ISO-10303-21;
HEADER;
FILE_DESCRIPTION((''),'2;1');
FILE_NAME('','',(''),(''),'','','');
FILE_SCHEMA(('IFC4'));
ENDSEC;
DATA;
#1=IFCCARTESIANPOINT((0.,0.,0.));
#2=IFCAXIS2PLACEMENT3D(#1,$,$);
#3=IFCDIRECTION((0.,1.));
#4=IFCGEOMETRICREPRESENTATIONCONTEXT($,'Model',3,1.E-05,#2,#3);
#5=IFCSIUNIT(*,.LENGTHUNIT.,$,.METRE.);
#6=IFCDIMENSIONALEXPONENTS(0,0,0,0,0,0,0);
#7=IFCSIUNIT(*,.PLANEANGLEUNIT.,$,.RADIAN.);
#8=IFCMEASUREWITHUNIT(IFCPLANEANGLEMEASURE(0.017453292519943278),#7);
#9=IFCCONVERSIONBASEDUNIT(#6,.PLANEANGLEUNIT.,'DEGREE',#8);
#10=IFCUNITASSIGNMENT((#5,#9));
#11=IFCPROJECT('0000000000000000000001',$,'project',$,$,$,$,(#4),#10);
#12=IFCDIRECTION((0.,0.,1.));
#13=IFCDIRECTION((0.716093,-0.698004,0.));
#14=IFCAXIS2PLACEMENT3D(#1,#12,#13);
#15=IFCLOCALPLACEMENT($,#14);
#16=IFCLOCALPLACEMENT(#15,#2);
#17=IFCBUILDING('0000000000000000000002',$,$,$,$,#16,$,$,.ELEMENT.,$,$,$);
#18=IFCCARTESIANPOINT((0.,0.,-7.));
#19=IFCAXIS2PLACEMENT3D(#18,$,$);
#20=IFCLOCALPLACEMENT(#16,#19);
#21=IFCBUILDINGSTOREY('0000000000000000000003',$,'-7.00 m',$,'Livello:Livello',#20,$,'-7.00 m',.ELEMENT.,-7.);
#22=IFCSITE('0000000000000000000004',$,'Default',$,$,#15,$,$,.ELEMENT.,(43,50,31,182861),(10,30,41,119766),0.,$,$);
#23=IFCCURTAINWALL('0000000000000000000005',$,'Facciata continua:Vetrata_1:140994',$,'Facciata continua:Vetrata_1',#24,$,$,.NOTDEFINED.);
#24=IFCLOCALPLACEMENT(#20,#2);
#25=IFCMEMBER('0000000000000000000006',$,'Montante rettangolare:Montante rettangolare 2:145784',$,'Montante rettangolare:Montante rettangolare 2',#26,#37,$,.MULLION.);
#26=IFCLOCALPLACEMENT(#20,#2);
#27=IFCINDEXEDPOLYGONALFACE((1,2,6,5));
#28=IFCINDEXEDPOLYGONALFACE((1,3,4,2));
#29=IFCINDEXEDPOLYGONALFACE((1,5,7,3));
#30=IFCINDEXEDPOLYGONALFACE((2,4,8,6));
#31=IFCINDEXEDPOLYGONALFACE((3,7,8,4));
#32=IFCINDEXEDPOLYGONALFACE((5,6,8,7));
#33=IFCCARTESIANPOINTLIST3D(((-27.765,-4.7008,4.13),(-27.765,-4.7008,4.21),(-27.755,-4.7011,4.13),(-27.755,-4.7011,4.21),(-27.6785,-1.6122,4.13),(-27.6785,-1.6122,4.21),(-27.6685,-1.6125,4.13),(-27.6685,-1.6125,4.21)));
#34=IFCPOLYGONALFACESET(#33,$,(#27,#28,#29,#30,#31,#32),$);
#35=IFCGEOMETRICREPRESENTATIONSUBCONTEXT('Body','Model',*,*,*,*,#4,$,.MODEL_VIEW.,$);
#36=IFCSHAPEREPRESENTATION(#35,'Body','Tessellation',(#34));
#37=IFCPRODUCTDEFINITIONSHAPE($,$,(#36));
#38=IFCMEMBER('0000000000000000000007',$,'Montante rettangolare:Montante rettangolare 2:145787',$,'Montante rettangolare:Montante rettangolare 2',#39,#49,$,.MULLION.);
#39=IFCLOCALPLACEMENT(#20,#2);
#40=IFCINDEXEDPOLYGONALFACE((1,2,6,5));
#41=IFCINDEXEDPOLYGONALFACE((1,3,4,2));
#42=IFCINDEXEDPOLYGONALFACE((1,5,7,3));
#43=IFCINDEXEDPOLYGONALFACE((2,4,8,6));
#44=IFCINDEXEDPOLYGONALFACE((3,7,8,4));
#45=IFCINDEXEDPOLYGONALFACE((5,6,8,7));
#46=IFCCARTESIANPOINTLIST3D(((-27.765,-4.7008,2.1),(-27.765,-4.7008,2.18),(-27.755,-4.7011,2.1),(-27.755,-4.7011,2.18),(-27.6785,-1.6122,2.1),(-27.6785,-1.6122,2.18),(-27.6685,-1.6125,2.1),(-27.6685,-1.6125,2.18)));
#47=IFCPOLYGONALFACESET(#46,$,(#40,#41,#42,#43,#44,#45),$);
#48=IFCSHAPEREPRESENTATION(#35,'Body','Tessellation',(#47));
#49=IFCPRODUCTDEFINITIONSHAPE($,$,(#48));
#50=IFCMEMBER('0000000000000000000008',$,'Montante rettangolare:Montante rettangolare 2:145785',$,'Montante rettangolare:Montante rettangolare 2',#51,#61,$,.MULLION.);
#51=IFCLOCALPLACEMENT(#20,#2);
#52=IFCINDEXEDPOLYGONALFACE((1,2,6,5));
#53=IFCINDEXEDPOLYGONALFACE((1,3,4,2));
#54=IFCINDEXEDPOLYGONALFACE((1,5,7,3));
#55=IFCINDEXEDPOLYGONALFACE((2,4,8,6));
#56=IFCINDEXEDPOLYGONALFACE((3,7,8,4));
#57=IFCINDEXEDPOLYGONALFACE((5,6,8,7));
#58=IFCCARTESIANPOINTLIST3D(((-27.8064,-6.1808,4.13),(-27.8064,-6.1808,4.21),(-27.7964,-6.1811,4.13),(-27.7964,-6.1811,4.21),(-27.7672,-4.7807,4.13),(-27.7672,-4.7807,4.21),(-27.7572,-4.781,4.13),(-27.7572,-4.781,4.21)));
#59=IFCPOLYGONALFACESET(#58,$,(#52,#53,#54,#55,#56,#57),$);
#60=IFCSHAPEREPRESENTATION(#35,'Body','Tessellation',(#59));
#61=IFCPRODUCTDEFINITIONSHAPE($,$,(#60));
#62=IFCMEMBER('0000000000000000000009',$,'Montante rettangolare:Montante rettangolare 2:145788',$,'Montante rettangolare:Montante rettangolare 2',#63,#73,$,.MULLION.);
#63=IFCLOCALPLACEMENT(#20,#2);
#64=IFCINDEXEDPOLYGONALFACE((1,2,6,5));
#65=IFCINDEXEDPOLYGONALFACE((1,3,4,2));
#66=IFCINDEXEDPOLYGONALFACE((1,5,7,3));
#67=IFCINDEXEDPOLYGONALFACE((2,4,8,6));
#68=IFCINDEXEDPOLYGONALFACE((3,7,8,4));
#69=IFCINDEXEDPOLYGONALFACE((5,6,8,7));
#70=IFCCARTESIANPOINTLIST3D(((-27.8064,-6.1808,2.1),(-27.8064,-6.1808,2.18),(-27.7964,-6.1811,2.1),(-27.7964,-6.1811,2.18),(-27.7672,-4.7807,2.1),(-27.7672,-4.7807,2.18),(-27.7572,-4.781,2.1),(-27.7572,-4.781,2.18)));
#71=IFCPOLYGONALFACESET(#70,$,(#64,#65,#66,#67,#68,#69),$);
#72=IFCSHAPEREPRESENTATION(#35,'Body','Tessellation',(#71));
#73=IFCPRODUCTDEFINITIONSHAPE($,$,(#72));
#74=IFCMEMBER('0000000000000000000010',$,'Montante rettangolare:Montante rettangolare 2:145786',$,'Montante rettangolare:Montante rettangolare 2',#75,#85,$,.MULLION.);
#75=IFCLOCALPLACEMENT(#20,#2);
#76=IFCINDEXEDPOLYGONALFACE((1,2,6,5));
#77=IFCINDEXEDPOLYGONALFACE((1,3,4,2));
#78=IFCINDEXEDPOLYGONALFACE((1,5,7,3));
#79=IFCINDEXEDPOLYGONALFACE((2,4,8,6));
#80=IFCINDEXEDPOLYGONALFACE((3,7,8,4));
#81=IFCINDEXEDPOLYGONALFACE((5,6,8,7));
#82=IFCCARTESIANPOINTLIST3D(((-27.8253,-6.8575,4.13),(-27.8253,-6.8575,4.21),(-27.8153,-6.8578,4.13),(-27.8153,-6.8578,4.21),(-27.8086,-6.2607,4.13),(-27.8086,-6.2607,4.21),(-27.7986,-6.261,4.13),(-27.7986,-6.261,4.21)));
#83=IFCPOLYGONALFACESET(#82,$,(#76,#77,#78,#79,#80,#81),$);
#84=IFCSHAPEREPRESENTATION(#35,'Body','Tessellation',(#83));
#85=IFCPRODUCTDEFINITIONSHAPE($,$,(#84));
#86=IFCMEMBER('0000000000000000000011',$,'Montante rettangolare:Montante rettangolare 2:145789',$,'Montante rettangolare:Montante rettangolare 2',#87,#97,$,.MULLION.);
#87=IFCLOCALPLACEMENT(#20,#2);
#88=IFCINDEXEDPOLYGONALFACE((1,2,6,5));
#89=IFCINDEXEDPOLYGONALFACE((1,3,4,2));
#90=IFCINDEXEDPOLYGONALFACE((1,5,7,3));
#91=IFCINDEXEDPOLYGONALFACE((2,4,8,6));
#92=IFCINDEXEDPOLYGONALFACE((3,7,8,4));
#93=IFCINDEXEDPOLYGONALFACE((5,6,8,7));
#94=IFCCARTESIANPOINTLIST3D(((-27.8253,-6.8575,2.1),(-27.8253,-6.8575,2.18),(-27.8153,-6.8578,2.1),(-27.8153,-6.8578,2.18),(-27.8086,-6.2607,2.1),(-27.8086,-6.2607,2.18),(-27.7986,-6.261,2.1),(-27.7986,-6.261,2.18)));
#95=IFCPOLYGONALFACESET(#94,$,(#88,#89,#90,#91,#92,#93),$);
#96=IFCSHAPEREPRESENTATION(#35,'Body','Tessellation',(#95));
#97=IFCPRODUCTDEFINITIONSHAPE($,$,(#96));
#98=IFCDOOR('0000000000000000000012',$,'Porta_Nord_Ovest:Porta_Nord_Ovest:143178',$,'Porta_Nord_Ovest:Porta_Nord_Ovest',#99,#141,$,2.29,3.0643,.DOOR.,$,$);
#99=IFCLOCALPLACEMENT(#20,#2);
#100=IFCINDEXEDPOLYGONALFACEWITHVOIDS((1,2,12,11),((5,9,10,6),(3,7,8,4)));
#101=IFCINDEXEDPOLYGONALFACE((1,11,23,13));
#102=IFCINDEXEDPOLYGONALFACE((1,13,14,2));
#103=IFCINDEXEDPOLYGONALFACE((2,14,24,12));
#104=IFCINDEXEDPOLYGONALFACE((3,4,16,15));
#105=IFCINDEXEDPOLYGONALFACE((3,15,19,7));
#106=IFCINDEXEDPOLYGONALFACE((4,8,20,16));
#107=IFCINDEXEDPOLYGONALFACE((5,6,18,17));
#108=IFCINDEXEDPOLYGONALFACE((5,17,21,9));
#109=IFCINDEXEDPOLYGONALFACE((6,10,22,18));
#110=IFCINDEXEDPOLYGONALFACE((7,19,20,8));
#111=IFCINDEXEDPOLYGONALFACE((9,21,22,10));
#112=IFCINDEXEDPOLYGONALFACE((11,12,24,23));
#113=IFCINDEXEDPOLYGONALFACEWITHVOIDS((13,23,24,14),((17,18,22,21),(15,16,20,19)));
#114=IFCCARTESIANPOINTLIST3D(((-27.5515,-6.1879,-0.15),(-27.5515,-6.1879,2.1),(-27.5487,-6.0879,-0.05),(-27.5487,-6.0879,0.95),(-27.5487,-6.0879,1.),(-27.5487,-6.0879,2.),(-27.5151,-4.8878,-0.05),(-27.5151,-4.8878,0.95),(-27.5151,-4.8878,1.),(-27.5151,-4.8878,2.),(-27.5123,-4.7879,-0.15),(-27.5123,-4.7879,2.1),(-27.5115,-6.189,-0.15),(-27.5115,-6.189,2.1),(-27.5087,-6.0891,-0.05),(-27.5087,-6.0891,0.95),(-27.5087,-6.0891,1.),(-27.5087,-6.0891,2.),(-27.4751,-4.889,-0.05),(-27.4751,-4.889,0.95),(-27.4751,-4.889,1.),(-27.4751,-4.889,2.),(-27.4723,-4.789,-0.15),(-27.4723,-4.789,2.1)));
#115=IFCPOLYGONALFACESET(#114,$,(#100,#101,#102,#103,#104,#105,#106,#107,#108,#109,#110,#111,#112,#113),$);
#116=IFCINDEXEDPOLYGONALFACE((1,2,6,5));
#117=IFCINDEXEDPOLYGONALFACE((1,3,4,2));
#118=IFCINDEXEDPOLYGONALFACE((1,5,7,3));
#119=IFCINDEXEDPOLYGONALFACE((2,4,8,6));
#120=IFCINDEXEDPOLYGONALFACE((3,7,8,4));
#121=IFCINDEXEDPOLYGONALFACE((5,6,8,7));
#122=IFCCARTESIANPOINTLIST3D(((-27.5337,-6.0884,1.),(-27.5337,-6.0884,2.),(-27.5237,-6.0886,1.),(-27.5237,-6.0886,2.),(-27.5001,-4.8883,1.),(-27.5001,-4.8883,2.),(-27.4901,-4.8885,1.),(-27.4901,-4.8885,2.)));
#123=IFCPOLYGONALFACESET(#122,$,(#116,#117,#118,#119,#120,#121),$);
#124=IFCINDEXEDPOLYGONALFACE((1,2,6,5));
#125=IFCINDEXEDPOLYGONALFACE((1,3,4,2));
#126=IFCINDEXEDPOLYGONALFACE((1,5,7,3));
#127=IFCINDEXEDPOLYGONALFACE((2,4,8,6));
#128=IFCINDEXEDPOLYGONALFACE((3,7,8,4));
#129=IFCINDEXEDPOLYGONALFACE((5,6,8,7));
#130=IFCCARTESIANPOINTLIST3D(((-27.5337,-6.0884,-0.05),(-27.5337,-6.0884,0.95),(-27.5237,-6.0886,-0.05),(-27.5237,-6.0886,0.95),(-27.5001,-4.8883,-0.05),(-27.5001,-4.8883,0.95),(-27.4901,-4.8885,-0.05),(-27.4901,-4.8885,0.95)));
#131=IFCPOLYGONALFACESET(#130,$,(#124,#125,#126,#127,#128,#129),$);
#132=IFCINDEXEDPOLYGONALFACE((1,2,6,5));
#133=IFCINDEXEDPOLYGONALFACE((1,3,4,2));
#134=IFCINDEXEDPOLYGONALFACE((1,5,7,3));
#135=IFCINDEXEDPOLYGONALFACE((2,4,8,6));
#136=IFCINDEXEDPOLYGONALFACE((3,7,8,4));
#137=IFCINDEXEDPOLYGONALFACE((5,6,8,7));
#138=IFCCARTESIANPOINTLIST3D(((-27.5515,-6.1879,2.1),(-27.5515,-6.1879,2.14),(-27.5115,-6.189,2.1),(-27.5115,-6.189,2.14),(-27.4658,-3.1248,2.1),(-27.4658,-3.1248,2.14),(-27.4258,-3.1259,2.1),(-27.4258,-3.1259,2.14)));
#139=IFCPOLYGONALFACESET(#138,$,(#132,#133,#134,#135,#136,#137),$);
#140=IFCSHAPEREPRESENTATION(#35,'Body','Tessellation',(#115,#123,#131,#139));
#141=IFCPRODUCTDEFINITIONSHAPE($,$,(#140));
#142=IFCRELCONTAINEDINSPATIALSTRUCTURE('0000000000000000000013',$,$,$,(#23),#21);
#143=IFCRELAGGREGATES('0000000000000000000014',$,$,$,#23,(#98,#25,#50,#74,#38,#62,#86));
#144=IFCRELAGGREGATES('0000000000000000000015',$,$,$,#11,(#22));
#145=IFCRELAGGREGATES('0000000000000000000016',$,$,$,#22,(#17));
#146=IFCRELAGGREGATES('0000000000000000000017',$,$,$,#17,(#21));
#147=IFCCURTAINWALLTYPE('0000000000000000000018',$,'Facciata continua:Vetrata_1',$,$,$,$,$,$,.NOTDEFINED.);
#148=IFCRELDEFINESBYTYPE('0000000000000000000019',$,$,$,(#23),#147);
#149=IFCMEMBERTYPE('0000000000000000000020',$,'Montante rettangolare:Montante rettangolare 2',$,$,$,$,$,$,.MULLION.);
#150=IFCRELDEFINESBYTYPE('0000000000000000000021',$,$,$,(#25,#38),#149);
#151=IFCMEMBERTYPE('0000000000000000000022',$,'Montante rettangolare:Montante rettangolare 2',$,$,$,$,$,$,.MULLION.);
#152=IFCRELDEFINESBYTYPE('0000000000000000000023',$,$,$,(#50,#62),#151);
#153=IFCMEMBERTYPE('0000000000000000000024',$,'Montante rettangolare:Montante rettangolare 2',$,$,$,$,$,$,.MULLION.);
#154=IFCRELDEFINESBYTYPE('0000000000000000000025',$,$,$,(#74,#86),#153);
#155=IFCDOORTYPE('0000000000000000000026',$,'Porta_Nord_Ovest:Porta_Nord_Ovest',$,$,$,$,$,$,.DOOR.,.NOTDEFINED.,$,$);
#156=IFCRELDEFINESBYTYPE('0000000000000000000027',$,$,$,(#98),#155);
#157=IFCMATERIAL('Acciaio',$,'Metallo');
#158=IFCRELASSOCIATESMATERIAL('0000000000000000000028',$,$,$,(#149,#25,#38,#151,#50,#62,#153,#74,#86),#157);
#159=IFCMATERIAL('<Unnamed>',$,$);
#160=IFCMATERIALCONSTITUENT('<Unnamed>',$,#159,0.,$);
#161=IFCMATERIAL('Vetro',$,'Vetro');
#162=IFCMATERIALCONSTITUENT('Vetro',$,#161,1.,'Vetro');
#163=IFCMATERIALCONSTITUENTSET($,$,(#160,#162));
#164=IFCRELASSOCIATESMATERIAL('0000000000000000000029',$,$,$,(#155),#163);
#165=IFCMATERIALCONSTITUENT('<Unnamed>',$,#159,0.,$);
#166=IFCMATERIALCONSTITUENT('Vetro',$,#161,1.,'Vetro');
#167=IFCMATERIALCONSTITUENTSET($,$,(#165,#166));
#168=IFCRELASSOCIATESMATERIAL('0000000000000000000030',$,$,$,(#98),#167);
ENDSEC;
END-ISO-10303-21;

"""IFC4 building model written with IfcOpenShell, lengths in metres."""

from ifc_helpers import new_model, entity, si_unit, converted_unit, direction, frame, origin, place, context, subcontext, project, spatial, indexed_curve, outline, extrude, source, transform, mapped, material, constituent, constituent_set, type_object, type_shapes, element, aggregate, save


model = new_model("IFC4")

# Units and contexts
model_context = context("Model", 3, precision=1e-05, world=origin(), true_north=direction((0.0, 1.0)))
body_context = subcontext(model_context, "Body", "Model", "MODEL_VIEW")
ifc_project = project(units=[si_unit("LENGTHUNIT", "METRE"), converted_unit("PLANEANGLEUNIT", "DEGREE", entity("IfcPlaneAngleMeasure", 0.017453292519943278), si_unit("PLANEANGLEUNIT", "RADIAN"), dimensions=[0, 0, 0, 0, 0, 0, 0])], contexts=[model_context])

# Site, building, storey
site_placement = place(None, frame((0.0, 0.0, 0.0), z_axis=(0.0, 0.0, 1.0), x_axis=(0.716093, -0.698004, 0.0)))
site = spatial("IfcSite", under=ifc_project, at=site_placement, Name="Default", CompositionType="ELEMENT", RefLatitude=(43, 50, 31, 182861), RefLongitude=(10, 30, 41, 119766), RefElevation=0.0)
building_placement = place(site_placement, origin())
building = spatial("IfcBuilding", under=site, at=building_placement, CompositionType="ELEMENT")
storey_placement = place(building_placement, frame((0.0, 0.0, -7.0)))
storey = spatial("IfcBuildingStorey", under=building, at=storey_placement, Name="-7.00 m", ObjectType="Livello:Livello", LongName="-7.00 m", CompositionType="ELEMENT", Elevation=-7.0)

# Curtain wall
ifc_material_1 = material(Name="Acciaio", Category="Metallo")
curtain_wall_type_1 = type_object("IfcCurtainWallType", Name="Facciata continua:Vetrata_1", PredefinedType="NOTDEFINED")
curtain_wall_1_placement = place(storey_placement, frame((0.0, 0.0, 7.0)))
curtain_wall_1 = element("IfcCurtainWall", 1, at=curtain_wall_1_placement, inside=storey, type_object=curtain_wall_type_1, Name="Facciata continua:Vetrata_1:140994", ObjectType="Facciata continua:Vetrata_1", PredefinedType="NOTDEFINED")

# Members
member_type_1 = type_object("IfcMemberType", Name="Montante rettangolare:Montante rettangolare 2", PredefinedType="MULLION", material=ifc_material_1)
shared_shape_1 = source(origin(), body_context, "Body", "SweptSolid", [
    extrude(outline(indexed_curve([(-0.04, -0.005), (0.04, -0.005), (0.04, 0.005), (-0.04, 0.005), (-0.04, -0.005)], self_intersect=False)), frame((0.0, 0.01, -3.0898), z_axis=(0.0, 0.0, 1.0), x_axis=(-1.0, 0.0, 0.0)), (0.0, 0.0, 1.0), 3.0898),
])
type_shapes(member_type_1, [shared_shape_1])
member_1_placement = place(curtain_wall_1_placement, frame((-27.75, -4.7012, -2.83), z_axis=(-0.02798, -0.999608, 0.0), x_axis=(0.0, 0.0, 1.0)))
member_1 = element("IfcMember", 2, at=member_1_placement, type_object=member_type_1, material=ifc_material_1, Name="Montante rettangolare:Montante rettangolare 2:145784", ObjectType="Montante rettangolare:Montante rettangolare 2", PredefinedType="MULLION", context=body_context, shape_type="MappedRepresentation", body=[
    mapped(shared_shape_1, transform((0.0, 0.0, 0.0), scale=1.0)),
])
member_2_placement = place(curtain_wall_1_placement, frame((-27.75, -4.7012, -4.86), z_axis=(-0.02798, -0.999608, 0.0), x_axis=(0.0, 0.0, 1.0)))
member_2 = element("IfcMember", 3, at=member_2_placement, type_object=member_type_1, material=ifc_material_1, Name="Montante rettangolare:Montante rettangolare 2:145787", ObjectType="Montante rettangolare:Montante rettangolare 2", PredefinedType="MULLION", context=body_context, shape_type="MappedRepresentation", body=[
    mapped(shared_shape_1, transform((0.0, 0.0, 0.0), scale=1.0)),
])
member_type_2 = type_object("IfcMemberType", Name="Montante rettangolare:Montante rettangolare 2", PredefinedType="MULLION", material=ifc_material_1)
shared_shape_2 = source(origin(), body_context, "Body", "SweptSolid", [
    extrude(outline(indexed_curve([(-0.04, -0.005), (0.04, -0.005), (0.04, 0.005), (-0.04, 0.005), (-0.04, -0.005)], self_intersect=False)), frame((0.0, 0.01, -1.4006), z_axis=(0.0, 0.0, 1.0), x_axis=(-1.0, 0.0, 0.0)), (0.0, 0.0, 1.0), 1.4006),
])
type_shapes(member_type_2, [shared_shape_2])
member_3_placement = place(curtain_wall_1_placement, frame((-27.7914, -6.1812, -2.83), z_axis=(-0.02798, -0.999608, 0.0), x_axis=(0.0, 0.0, 1.0)))
member_3 = element("IfcMember", 4, at=member_3_placement, type_object=member_type_2, material=ifc_material_1, Name="Montante rettangolare:Montante rettangolare 2:145785", ObjectType="Montante rettangolare:Montante rettangolare 2", PredefinedType="MULLION", context=body_context, shape_type="MappedRepresentation", body=[
    mapped(shared_shape_2, transform((0.0, 0.0, 0.0), scale=1.0)),
])
member_4_placement = place(curtain_wall_1_placement, frame((-27.7914, -6.1812, -4.86), z_axis=(-0.02798, -0.999608, 0.0), x_axis=(0.0, 0.0, 1.0)))
member_4 = element("IfcMember", 5, at=member_4_placement, type_object=member_type_2, material=ifc_material_1, Name="Montante rettangolare:Montante rettangolare 2:145788", ObjectType="Montante rettangolare:Montante rettangolare 2", PredefinedType="MULLION", context=body_context, shape_type="MappedRepresentation", body=[
    mapped(shared_shape_2, transform((0.0, 0.0, 0.0), scale=1.0)),
])
member_type_3 = type_object("IfcMemberType", Name="Montante rettangolare:Montante rettangolare 2", PredefinedType="MULLION", material=ifc_material_1)
shared_shape_3 = source(origin(), body_context, "Body", "SweptSolid", [
    extrude(outline(indexed_curve([(-0.04, -0.005), (0.04, -0.005), (0.04, 0.005), (-0.04, 0.005), (-0.04, -0.005)], self_intersect=False)), frame((0.0, 0.01, -0.597), z_axis=(0.0, 0.0, 1.0), x_axis=(-1.0, 0.0, 0.0)), (0.0, 0.0, 1.0), 0.597),
])
type_shapes(member_type_3, [shared_shape_3])
member_5_placement = place(curtain_wall_1_placement, frame((-27.8103, -6.8579, -2.83), z_axis=(-0.02798, -0.999608, 0.0), x_axis=(0.0, 0.0, 1.0)))
member_5 = element("IfcMember", 6, at=member_5_placement, type_object=member_type_3, material=ifc_material_1, Name="Montante rettangolare:Montante rettangolare 2:145786", ObjectType="Montante rettangolare:Montante rettangolare 2", PredefinedType="MULLION", context=body_context, shape_type="MappedRepresentation", body=[
    mapped(shared_shape_3, transform((0.0, 0.0, 0.0), scale=1.0)),
])
member_6_placement = place(curtain_wall_1_placement, frame((-27.8103, -6.8579, -4.86), z_axis=(-0.02798, -0.999608, 0.0), x_axis=(0.0, 0.0, 1.0)))
member_6 = element("IfcMember", 7, at=member_6_placement, type_object=member_type_3, material=ifc_material_1, Name="Montante rettangolare:Montante rettangolare 2:145789", ObjectType="Montante rettangolare:Montante rettangolare 2", PredefinedType="MULLION", context=body_context, shape_type="MappedRepresentation", body=[
    mapped(shared_shape_3, transform((0.0, 0.0, 0.0), scale=1.0)),
])

# Door
ifc_material_2 = material(Name="<Unnamed>")
ifc_constituent_1 = constituent(ifc_material_2, Name="<Unnamed>", fraction=0.0)
ifc_material_3 = material(Name="Vetro", Category="Vetro")
ifc_constituent_2 = constituent(ifc_material_3, Name="Vetro", Category="Vetro", fraction=1.0)
ifc_constituent_set_1 = constituent_set(constituents=[ifc_constituent_1, ifc_constituent_2])
ifc_constituent_3 = constituent(ifc_material_2, Name="<Unnamed>", fraction=0.0)
ifc_constituent_4 = constituent(ifc_material_3, Name="Vetro", Category="Vetro", fraction=1.0)
ifc_constituent_set_2 = constituent_set(constituents=[ifc_constituent_3, ifc_constituent_4])
door_type = type_object("IfcDoorType", Name="Porta_Nord_Ovest:Porta_Nord_Ovest", OperationType="NOTDEFINED", PredefinedType="DOOR", material=ifc_constituent_set_2)
shared_shape_4 = source(origin(), body_context, "Body", "SweptSolid", [
    extrude(outline(indexed_curve([(-0.7003, -1.125), (0.7003, -1.125), (0.7003, 1.125), (-0.7003, 1.125), (-0.7003, -1.125)], self_intersect=False), holes=[indexed_curve([(-0.6003, -0.025), (0.6003, -0.025), (0.6003, -1.025), (-0.6003, -1.025), (-0.6003, -0.025)], self_intersect=False), indexed_curve([(-0.6003, 0.025), (-0.6003, 1.025), (0.6003, 1.025), (0.6003, 0.025), (-0.6003, 0.025)], self_intersect=False)]), frame((0.0, -0.24, 0.915), z_axis=(0.0, -1.0, 0.0), x_axis=(-1.0, 0.0, 0.0)), (0.0, 0.0, 1.0), 0.04),
    extrude(outline(indexed_curve([(-0.005, -0.6003), (0.005, -0.6003), (0.005, 0.6003), (-0.005, 0.6003), (-0.005, -0.6003)], self_intersect=False)), frame((0.0, -0.26, 0.94), z_axis=(0.0, 0.0, 1.0), x_axis=(0.0, -1.0, 0.0)), (0.0, 0.0, 1.0), 1.0),
    extrude(outline(indexed_curve([(-0.005, -0.6003), (0.005, -0.6003), (0.005, 0.6003), (-0.005, 0.6003), (-0.005, -0.6003)], self_intersect=False)), frame((0.0, -0.26, -0.11), z_axis=(0.0, 0.0, 1.0), x_axis=(0.0, -1.0, 0.0)), (0.0, 0.0, 1.0), 1.0),
    extrude(outline(indexed_curve([(-0.02, -1.5322), (0.02, -1.5322), (0.02, 1.5322), (-0.02, 1.5322), (-0.02, -1.5322)], self_intersect=False)), frame((0.8319, -0.26, 2.04), z_axis=(0.0, 0.0, 1.0), x_axis=(0.0, -1.0, 0.0)), (0.0, 0.0, 1.0), 0.04),
])
type_shapes(door_type, [shared_shape_4])
door_placement = place(curtain_wall_1_placement, frame((-27.7718, -5.4812, -6.94), z_axis=(0.0, 0.0, 1.0), x_axis=(0.02798, 0.999608, 0.0)))
door = element("IfcDoor", 8, at=door_placement, type_object=door_type, material=ifc_constituent_set_1, Name="Porta_Nord_Ovest:Porta_Nord_Ovest:143178", ObjectType="Porta_Nord_Ovest:Porta_Nord_Ovest", OverallHeight=2.29, OverallWidth=3.0643, PredefinedType="DOOR", context=body_context, shape_type="MappedRepresentation", body=[
    mapped(shared_shape_4, transform((0.0, 0.0, 0.0), scale=1.0)),
])
aggregate(curtain_wall_1, [door, member_1, member_3, member_5, member_2, member_4, member_6])

save(model, "model.ifc")
